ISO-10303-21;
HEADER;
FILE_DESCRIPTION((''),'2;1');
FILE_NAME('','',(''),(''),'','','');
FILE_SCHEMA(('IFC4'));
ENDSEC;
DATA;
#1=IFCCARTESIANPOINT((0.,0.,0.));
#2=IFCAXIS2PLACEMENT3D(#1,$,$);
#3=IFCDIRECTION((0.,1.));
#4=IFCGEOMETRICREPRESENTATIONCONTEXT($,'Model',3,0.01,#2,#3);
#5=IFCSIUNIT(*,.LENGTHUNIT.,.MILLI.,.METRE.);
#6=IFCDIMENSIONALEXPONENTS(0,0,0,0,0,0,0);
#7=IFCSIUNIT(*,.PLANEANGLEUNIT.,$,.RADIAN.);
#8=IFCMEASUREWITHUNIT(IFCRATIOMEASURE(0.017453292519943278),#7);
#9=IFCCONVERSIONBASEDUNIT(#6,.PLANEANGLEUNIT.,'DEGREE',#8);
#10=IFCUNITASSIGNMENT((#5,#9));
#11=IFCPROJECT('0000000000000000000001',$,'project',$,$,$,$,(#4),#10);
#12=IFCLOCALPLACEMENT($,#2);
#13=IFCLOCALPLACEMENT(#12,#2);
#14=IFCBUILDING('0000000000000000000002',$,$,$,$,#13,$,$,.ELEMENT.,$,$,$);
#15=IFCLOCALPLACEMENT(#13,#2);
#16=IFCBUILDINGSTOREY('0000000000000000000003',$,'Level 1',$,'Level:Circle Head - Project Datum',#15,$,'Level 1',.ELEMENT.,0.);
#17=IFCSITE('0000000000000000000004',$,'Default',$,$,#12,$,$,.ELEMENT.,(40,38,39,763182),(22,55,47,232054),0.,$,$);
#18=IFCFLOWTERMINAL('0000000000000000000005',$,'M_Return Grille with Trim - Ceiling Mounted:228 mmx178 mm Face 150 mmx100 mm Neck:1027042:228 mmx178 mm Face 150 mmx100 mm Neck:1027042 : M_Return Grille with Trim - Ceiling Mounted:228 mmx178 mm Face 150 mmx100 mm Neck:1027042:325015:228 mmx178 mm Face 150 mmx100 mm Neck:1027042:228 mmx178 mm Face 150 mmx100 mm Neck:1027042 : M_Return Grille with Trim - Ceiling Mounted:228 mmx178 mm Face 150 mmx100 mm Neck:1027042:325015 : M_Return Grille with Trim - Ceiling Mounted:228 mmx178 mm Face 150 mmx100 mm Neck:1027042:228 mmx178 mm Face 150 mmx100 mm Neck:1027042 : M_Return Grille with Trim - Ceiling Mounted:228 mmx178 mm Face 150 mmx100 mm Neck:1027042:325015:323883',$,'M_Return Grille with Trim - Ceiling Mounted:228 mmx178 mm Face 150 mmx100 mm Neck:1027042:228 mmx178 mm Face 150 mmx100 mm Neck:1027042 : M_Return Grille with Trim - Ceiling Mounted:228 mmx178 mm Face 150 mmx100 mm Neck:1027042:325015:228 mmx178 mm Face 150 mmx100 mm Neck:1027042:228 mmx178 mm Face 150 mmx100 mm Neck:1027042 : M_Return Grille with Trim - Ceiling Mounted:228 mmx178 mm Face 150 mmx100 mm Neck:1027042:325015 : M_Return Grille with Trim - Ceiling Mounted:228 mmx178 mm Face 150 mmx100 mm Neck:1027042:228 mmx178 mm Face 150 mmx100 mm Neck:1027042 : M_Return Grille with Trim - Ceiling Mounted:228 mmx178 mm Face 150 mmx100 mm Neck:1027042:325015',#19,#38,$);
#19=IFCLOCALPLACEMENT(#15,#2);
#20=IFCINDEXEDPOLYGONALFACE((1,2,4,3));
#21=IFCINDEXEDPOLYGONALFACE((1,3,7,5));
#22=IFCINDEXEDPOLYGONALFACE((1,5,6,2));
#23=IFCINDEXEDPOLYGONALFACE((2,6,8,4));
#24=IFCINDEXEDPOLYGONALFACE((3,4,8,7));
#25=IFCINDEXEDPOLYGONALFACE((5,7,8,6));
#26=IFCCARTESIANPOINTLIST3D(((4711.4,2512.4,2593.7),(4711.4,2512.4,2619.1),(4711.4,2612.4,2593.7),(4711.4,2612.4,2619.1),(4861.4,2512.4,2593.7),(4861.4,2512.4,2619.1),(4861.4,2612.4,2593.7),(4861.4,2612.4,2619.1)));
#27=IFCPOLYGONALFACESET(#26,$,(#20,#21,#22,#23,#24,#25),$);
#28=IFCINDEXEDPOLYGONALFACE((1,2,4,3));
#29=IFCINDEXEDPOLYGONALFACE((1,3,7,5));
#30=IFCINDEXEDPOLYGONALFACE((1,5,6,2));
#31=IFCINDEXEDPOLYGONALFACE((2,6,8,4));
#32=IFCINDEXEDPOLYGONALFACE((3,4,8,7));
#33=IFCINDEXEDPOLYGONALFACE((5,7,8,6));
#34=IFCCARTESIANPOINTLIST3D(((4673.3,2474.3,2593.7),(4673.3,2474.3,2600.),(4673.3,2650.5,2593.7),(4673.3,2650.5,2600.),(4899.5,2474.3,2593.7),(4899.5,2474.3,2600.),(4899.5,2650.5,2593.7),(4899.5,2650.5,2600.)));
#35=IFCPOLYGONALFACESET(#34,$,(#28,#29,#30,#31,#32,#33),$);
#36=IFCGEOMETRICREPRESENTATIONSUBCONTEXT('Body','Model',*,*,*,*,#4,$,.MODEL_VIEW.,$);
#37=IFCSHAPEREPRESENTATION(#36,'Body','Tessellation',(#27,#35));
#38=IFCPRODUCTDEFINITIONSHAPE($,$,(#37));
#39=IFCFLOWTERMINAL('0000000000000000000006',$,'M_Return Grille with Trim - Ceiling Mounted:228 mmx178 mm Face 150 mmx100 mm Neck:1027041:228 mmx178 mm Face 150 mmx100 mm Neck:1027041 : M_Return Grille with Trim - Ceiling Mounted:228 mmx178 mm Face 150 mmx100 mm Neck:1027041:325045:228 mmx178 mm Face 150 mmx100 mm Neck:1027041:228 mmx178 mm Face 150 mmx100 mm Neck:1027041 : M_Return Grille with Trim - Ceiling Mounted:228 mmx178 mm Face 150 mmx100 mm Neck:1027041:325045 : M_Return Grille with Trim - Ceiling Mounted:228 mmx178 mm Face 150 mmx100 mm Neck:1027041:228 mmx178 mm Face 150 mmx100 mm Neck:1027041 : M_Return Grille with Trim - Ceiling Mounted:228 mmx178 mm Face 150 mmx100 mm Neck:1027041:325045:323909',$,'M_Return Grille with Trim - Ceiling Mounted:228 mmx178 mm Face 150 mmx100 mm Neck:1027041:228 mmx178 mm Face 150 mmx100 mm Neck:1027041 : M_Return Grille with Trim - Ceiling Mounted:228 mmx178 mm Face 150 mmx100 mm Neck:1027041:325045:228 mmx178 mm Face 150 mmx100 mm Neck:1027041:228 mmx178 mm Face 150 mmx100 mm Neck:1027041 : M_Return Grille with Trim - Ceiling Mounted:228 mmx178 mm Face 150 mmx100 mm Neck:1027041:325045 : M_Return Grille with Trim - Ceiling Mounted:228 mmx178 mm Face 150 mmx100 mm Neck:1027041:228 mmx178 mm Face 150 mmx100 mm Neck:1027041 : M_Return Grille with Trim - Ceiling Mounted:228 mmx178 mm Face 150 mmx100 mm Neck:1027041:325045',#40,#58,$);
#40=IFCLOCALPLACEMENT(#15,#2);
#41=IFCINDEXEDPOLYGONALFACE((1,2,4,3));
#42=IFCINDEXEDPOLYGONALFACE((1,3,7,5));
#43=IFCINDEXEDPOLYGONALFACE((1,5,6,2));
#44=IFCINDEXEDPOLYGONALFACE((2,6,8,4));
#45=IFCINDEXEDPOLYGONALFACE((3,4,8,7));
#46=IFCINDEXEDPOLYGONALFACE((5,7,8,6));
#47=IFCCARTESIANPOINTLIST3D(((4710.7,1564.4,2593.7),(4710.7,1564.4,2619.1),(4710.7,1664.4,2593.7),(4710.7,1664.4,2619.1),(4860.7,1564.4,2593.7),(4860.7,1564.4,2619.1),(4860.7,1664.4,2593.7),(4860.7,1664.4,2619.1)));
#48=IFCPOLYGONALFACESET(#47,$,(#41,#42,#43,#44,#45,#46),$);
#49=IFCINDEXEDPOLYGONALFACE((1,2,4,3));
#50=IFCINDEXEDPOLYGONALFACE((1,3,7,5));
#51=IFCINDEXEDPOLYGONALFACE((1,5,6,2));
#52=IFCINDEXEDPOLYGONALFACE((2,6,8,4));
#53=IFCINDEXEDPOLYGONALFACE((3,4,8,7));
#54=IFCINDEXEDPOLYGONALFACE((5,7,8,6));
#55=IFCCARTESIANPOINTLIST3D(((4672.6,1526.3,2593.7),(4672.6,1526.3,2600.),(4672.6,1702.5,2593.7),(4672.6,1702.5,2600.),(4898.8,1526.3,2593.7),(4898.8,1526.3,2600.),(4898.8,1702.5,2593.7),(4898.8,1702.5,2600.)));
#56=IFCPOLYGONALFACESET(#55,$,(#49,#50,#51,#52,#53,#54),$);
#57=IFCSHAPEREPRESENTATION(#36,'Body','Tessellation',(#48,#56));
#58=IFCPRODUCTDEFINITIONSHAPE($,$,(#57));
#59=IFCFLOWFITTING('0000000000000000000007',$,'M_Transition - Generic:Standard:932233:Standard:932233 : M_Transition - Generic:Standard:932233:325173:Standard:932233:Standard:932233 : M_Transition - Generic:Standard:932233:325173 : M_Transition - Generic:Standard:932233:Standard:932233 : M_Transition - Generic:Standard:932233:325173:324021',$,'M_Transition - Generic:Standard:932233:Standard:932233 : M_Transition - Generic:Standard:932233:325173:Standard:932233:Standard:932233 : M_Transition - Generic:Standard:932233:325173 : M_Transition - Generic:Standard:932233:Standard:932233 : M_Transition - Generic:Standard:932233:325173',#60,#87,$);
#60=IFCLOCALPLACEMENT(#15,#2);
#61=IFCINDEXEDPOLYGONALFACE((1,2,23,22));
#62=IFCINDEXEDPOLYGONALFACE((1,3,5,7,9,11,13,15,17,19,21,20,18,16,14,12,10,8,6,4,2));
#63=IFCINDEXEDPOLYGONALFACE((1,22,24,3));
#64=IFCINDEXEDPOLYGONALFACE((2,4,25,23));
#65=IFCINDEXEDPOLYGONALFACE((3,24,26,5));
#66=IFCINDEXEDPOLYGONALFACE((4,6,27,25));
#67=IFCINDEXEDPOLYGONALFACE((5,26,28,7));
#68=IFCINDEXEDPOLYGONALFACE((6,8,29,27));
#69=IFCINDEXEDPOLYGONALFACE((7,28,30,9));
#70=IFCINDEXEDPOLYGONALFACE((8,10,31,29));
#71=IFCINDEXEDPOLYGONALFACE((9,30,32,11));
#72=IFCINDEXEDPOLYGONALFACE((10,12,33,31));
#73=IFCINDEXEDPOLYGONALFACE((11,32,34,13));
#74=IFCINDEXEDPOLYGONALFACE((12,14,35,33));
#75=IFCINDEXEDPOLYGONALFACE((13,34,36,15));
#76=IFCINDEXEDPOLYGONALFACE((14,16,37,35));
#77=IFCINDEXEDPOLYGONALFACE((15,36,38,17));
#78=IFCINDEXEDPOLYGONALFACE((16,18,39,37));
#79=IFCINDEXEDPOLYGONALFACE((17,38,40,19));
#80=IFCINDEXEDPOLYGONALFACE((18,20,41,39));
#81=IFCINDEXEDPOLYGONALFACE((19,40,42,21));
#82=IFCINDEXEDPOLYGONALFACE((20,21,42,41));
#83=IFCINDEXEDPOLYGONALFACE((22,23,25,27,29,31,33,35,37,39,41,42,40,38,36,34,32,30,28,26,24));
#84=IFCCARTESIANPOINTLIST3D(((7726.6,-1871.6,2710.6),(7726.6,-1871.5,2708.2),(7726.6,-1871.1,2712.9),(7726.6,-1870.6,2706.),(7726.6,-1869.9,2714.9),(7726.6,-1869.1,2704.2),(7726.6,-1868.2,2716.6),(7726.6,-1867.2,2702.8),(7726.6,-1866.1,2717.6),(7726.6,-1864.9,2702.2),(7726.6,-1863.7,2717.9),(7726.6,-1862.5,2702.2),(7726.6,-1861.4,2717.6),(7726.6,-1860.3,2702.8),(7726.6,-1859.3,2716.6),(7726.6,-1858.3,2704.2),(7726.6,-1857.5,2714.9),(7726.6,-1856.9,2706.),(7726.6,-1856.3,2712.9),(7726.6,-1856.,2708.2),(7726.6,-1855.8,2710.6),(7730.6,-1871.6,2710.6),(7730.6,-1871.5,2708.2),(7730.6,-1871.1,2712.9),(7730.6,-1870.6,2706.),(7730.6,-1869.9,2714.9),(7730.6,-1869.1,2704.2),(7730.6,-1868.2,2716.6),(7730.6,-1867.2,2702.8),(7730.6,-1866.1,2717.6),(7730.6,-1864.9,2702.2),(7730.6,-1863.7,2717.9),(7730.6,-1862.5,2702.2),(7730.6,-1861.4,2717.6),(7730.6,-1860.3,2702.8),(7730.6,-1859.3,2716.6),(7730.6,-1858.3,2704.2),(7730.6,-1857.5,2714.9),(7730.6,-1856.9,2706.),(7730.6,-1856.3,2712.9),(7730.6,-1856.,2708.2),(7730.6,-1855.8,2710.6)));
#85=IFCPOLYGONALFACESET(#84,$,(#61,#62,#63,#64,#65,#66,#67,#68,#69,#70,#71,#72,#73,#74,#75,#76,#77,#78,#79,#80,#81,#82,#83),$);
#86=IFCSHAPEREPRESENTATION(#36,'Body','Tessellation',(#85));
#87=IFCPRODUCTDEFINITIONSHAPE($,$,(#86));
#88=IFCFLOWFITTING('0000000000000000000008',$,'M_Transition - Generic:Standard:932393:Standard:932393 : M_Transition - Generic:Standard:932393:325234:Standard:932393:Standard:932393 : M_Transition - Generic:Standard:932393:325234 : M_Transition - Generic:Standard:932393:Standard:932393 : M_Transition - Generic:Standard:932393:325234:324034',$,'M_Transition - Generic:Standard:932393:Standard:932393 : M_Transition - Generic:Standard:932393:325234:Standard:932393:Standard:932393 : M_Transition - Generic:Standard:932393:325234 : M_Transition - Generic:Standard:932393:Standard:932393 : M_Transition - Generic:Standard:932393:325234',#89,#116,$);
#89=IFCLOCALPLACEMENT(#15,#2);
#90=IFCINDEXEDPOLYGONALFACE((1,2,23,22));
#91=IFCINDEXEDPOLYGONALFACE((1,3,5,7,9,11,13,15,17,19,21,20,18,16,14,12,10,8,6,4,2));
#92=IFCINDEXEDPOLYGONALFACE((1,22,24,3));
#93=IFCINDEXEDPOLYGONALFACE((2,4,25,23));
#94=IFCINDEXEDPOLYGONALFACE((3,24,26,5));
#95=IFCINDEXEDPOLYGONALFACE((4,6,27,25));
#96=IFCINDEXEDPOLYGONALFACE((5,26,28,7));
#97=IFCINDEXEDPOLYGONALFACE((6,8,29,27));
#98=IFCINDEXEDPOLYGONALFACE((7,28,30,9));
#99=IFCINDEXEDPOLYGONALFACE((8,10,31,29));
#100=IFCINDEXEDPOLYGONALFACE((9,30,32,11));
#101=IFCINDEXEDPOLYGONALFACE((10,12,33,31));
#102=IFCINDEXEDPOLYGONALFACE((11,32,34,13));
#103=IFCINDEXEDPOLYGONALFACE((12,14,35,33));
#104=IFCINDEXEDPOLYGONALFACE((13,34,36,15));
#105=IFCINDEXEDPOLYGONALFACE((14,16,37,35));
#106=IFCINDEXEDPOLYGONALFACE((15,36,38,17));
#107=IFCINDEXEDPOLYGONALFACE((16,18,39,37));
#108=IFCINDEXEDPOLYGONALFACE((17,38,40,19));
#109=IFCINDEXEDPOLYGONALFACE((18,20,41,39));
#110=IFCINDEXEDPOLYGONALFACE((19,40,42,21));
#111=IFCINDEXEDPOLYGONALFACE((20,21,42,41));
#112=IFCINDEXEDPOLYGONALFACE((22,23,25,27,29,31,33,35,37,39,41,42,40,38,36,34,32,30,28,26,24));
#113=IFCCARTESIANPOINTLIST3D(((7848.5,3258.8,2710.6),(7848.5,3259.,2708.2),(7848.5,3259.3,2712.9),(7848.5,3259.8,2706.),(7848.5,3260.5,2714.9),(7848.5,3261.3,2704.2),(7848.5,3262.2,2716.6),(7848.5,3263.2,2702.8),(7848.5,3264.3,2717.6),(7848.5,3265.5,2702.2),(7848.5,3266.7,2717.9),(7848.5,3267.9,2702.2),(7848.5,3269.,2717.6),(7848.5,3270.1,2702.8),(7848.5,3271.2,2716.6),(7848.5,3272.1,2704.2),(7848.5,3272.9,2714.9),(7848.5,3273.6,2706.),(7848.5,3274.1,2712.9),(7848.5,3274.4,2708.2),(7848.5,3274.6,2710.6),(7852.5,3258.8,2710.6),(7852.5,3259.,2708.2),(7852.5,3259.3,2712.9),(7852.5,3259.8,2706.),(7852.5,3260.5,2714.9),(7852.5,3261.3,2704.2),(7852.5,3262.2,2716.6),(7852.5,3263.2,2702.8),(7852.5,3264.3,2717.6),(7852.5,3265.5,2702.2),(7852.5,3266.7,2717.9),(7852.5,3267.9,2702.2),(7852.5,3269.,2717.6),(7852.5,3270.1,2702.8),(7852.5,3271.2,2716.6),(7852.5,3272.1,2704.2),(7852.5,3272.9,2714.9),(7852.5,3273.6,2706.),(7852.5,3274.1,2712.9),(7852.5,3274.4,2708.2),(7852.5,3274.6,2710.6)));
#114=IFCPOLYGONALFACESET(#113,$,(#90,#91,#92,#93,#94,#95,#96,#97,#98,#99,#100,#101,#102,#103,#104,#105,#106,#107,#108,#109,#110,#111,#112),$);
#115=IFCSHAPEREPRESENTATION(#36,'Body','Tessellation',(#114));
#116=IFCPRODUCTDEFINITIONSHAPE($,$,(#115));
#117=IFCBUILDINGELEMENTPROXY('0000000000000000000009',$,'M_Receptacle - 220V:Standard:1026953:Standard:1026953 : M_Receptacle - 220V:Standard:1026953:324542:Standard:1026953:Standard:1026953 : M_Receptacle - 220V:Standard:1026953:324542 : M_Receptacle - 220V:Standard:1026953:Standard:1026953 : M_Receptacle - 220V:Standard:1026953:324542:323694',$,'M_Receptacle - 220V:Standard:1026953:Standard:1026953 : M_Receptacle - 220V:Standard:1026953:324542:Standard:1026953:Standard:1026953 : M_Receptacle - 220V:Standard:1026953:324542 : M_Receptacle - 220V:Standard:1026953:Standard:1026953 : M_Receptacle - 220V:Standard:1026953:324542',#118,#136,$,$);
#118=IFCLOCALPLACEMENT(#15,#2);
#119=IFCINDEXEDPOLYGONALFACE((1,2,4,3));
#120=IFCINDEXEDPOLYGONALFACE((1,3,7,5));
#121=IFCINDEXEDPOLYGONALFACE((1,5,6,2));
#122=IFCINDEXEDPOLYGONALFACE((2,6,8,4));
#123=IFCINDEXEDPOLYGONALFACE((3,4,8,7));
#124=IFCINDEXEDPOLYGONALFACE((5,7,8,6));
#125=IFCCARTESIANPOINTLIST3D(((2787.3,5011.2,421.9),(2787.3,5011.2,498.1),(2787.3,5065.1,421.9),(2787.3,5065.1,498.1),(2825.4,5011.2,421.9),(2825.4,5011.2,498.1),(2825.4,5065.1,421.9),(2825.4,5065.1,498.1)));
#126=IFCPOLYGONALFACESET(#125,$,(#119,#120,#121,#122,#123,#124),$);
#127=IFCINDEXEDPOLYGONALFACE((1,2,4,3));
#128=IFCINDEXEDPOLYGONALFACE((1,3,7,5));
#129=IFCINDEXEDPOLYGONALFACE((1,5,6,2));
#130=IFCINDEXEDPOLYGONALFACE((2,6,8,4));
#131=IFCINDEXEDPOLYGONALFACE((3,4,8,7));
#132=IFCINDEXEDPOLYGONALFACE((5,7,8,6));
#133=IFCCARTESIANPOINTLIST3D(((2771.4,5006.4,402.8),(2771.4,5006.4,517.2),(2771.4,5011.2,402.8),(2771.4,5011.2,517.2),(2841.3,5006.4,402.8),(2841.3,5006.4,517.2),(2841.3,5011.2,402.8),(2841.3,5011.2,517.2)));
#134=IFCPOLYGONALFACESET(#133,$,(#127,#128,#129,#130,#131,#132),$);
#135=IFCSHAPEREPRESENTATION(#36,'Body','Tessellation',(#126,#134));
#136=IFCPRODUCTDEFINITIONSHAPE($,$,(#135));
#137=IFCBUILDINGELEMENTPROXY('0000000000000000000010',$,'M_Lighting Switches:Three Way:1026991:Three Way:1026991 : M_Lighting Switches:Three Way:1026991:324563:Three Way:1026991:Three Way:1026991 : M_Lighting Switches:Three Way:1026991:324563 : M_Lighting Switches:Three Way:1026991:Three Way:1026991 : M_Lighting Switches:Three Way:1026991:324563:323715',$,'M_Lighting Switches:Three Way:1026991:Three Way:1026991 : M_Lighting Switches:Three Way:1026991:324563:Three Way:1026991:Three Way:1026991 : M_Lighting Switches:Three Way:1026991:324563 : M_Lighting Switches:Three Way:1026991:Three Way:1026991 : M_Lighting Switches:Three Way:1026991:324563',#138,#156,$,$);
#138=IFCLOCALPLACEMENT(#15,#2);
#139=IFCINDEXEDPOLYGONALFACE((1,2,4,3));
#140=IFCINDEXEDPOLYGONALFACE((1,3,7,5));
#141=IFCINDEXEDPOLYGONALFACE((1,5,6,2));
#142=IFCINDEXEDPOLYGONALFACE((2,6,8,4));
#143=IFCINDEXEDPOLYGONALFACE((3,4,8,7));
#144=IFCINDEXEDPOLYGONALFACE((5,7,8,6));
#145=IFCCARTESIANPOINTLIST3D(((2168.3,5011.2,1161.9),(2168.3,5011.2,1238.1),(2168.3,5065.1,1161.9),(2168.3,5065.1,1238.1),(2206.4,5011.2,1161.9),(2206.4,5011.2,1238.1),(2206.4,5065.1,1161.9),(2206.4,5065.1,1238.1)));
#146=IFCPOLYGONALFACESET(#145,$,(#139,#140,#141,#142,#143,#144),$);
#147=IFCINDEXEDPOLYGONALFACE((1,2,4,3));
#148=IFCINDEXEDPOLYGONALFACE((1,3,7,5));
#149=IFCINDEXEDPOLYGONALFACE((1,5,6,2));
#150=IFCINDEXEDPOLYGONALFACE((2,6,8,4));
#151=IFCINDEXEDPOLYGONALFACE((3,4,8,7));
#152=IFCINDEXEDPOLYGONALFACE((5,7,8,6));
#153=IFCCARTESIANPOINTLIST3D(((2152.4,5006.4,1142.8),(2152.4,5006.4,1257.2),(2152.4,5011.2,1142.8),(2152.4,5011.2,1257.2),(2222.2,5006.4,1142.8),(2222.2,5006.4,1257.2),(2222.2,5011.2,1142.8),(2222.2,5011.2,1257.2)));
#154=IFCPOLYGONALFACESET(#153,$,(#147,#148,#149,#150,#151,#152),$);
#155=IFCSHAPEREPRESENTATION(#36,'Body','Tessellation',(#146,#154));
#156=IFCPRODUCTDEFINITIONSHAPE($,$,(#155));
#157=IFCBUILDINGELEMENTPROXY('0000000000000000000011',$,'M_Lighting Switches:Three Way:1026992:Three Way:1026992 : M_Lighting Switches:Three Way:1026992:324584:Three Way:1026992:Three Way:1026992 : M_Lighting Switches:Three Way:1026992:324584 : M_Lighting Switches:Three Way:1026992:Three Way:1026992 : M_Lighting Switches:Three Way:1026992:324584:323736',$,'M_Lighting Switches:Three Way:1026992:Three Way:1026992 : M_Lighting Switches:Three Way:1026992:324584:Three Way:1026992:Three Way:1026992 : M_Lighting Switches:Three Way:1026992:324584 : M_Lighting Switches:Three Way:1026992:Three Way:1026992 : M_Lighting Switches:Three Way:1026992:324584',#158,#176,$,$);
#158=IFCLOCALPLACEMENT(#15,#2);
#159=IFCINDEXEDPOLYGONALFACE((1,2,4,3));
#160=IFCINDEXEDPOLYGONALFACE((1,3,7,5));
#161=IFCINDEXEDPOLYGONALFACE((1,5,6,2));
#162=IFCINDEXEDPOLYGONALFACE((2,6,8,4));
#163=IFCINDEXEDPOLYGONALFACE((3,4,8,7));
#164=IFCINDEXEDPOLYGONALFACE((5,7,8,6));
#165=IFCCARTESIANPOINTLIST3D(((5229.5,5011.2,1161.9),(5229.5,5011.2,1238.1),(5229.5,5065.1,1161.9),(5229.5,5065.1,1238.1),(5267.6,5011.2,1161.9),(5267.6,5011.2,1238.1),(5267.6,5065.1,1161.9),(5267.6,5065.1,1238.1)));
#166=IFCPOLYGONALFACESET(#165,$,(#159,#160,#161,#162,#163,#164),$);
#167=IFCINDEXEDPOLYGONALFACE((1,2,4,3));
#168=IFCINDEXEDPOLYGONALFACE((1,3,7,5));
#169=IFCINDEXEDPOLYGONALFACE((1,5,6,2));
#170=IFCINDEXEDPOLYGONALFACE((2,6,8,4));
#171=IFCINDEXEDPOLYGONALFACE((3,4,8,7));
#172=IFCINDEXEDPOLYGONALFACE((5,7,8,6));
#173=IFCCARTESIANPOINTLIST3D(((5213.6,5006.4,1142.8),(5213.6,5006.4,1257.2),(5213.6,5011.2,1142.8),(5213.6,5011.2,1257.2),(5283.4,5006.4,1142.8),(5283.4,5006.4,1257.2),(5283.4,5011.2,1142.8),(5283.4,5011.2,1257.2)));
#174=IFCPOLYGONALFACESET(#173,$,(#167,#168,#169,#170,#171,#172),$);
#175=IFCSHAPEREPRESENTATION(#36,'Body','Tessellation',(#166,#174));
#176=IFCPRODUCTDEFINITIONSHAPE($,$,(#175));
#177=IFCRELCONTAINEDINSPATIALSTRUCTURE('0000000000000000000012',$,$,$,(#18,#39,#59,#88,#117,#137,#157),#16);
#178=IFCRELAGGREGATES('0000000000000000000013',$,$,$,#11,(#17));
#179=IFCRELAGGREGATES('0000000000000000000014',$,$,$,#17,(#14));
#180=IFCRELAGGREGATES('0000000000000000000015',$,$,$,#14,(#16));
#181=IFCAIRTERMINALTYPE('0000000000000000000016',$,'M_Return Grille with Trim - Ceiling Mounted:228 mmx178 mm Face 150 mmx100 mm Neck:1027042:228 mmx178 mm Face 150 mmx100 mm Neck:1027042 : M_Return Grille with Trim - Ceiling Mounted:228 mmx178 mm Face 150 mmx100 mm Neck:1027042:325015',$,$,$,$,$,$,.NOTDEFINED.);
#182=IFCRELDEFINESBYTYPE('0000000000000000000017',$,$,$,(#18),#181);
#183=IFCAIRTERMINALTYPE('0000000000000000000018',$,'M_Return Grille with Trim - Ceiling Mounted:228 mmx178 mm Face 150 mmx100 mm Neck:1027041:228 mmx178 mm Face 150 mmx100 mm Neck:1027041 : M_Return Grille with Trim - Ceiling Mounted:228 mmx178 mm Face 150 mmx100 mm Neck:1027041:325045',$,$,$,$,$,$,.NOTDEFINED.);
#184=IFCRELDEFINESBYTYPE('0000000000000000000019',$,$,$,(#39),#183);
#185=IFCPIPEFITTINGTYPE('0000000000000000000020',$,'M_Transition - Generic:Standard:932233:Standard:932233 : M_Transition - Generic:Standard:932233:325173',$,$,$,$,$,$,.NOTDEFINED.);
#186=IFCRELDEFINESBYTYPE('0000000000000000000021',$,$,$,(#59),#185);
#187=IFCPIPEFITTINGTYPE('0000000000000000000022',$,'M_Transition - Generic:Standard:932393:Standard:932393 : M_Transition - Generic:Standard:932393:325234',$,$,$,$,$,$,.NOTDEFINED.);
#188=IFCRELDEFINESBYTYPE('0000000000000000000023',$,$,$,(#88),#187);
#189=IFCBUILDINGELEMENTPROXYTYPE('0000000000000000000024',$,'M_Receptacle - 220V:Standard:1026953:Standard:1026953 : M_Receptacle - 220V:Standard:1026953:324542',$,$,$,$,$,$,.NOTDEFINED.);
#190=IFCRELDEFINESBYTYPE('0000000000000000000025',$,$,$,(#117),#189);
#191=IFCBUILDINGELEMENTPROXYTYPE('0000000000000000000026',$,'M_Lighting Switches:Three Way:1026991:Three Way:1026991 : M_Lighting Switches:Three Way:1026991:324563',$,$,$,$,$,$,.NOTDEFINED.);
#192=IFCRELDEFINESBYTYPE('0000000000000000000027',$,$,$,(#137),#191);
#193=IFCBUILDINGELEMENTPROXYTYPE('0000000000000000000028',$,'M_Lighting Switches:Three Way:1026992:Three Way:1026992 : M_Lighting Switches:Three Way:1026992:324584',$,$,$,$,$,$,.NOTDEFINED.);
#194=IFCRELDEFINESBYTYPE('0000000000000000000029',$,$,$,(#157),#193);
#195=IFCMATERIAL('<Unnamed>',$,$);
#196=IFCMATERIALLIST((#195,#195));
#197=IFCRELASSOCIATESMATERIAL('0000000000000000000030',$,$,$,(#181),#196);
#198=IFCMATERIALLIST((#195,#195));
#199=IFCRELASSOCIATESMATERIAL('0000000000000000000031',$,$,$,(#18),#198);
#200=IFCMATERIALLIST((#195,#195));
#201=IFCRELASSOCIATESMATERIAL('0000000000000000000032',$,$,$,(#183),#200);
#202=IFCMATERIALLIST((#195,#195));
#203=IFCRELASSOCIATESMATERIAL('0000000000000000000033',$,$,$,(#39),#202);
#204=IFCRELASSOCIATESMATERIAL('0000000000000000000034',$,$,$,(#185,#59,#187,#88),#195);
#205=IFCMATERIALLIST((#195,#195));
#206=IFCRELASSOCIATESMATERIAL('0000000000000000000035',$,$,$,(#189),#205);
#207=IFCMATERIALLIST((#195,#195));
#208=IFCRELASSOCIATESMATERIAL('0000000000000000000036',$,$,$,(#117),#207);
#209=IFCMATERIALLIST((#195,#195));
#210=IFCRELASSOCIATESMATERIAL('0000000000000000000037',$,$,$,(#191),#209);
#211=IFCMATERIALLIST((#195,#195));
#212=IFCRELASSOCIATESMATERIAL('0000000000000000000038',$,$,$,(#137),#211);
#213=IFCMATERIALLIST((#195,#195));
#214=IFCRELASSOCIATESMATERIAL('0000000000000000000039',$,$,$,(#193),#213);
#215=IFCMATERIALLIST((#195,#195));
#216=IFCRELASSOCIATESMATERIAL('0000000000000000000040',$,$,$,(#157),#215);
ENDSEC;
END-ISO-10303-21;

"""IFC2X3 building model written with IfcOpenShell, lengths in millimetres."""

from ifc_helpers import new_model, entity, si_unit, converted_unit, direction, frame, frame_2d, origin, origin_2d_with_axis, place, context, subcontext, project, spatial, rectangle, circle, extrude, source, transform, mapped, material, material_list, type_object, type_shapes, element, save


model = new_model("IFC2X3")

# Units and contexts
model_context = context("Model", 3, precision=0.01, world=origin(), true_north=direction((0.0, 1.0)))
body_context = subcontext(model_context, "Body", "Model", "MODEL_VIEW")
ifc_project = project(units=[si_unit("LENGTHUNIT", "METRE", prefix="MILLI"), converted_unit("PLANEANGLEUNIT", "DEGREE", entity("IfcRatioMeasure", 0.017453292519943278), si_unit("PLANEANGLEUNIT", "RADIAN"), dimensions=[0, 0, 0, 0, 0, 0, 0])], contexts=[model_context])

# Site, building, storey
site_placement = place(None, origin())
site = spatial("IfcSite", under=ifc_project, at=site_placement, Name="Default", CompositionType="ELEMENT", RefLatitude=(40, 38, 39, 763182), RefLongitude=(22, 55, 47, 232054), RefElevation=0.0)
building_placement = place(site_placement, origin())
building = spatial("IfcBuilding", under=site, at=building_placement, CompositionType="ELEMENT")
storey_placement = place(building_placement, origin())
storey = spatial("IfcBuildingStorey", under=building, at=storey_placement, Name="Level 1", ObjectType="Level:Circle Head - Project Datum", LongName="Level 1", CompositionType="ELEMENT", Elevation=0.0)

# Flow terminals
ifc_material = material(Name="<Unnamed>")
ifc_material_list_1 = material_list([ifc_material, ifc_material])
ifc_material_list_2 = material_list([ifc_material, ifc_material])
air_terminal_type_1 = type_object("IfcAirTerminalType", Name="M_Return Grille with Trim - Ceiling Mounted:228 mmx178 mm Face 150 mmx100 mm Neck:1027042:228 mmx178 mm Face 150 mmx100 mm Neck:1027042 : M_Return Grille with Trim - Ceiling Mounted:228 mmx178 mm Face 150 mmx100 mm Neck:1027042:325015", PredefinedType="NOTDEFINED", material=ifc_material_list_2)
shared_shape_1 = source(origin(), body_context, "Body", "SweptSolid", [
    extrude(rectangle(XDim=100.0, YDim=150.0, at=frame_2d((0.0, 0.0), x_axis=(1.0, 0.0))), frame((4786.4, 2562.4, 2593.7), z_axis=(0.0, 0.0, 1.0), x_axis=(0.0, 1.0, 0.0)), (0.0, 0.0, 1.0), 25.4),
    extrude(rectangle(XDim=176.2, YDim=226.2, at=origin_2d_with_axis()), frame((4786.4, 2562.4, 2593.7), z_axis=(0.0, 0.0, 1.0), x_axis=(0.0, 1.0, 0.0)), (0.0, 0.0, 1.0), 6.3),
])
type_shapes(air_terminal_type_1, [shared_shape_1])
flow_terminal_1_placement = place(storey_placement, origin())
element("IfcFlowTerminal", 1, at=flow_terminal_1_placement, inside=storey, type_object=air_terminal_type_1, material=ifc_material_list_1, Name="M_Return Grille with Trim - Ceiling Mounted:228 mmx178 mm Face 150 mmx100 mm Neck:1027042:228 mmx178 mm Face 150 mmx100 mm Neck:1027042 : M_Return Grille with Trim - Ceiling Mounted:228 mmx178 mm Face 150 mmx100 mm Neck:1027042:325015:228 mmx178 mm Face 150 mmx100 mm Neck:1027042:228 mmx178 mm Face 150 mmx100 mm Neck:1027042 : M_Return Grille with Trim - Ceiling Mounted:228 mmx178 mm Face 150 mmx100 mm Neck:1027042:325015 : M_Return Grille with Trim - Ceiling Mounted:228 mmx178 mm Face 150 mmx100 mm Neck:1027042:228 mmx178 mm Face 150 mmx100 mm Neck:1027042 : M_Return Grille with Trim - Ceiling Mounted:228 mmx178 mm Face 150 mmx100 mm Neck:1027042:325015:323883", ObjectType="M_Return Grille with Trim - Ceiling Mounted:228 mmx178 mm Face 150 mmx100 mm Neck:1027042:228 mmx178 mm Face 150 mmx100 mm Neck:1027042 : M_Return Grille with Trim - Ceiling Mounted:228 mmx178 mm Face 150 mmx100 mm Neck:1027042:325015:228 mmx178 mm Face 150 mmx100 mm Neck:1027042:228 mmx178 mm Face 150 mmx100 mm Neck:1027042 : M_Return Grille with Trim - Ceiling Mounted:228 mmx178 mm Face 150 mmx100 mm Neck:1027042:325015 : M_Return Grille with Trim - Ceiling Mounted:228 mmx178 mm Face 150 mmx100 mm Neck:1027042:228 mmx178 mm Face 150 mmx100 mm Neck:1027042 : M_Return Grille with Trim - Ceiling Mounted:228 mmx178 mm Face 150 mmx100 mm Neck:1027042:325015", context=body_context, shape_type="MappedRepresentation", body=[
    mapped(shared_shape_1, transform((0.0, 0.0, 0.0), scale=1.0)),
])
ifc_material_list_3 = material_list([ifc_material, ifc_material])
ifc_material_list_4 = material_list([ifc_material, ifc_material])
air_terminal_type_2 = type_object("IfcAirTerminalType", Name="M_Return Grille with Trim - Ceiling Mounted:228 mmx178 mm Face 150 mmx100 mm Neck:1027041:228 mmx178 mm Face 150 mmx100 mm Neck:1027041 : M_Return Grille with Trim - Ceiling Mounted:228 mmx178 mm Face 150 mmx100 mm Neck:1027041:325045", PredefinedType="NOTDEFINED", material=ifc_material_list_4)
shared_shape_2 = source(origin(), body_context, "Body", "SweptSolid", [
    extrude(rectangle(XDim=100.0, YDim=150.0, at=frame_2d((0.0, 0.0), x_axis=(1.0, 0.0))), frame((4785.7, 1614.4, 2593.7), z_axis=(0.0, 0.0, 1.0), x_axis=(0.0, 1.0, 0.0)), (0.0, 0.0, 1.0), 25.4),
    extrude(rectangle(XDim=176.2, YDim=226.2, at=frame_2d((0.0, 0.0), x_axis=(1.0, 0.0))), frame((4785.7, 1614.4, 2593.7), z_axis=(0.0, 0.0, 1.0), x_axis=(0.0, 1.0, 0.0)), (0.0, 0.0, 1.0), 6.3),
])
type_shapes(air_terminal_type_2, [shared_shape_2])
flow_terminal_2_placement = place(storey_placement, origin())
element("IfcFlowTerminal", 2, at=flow_terminal_2_placement, inside=storey, type_object=air_terminal_type_2, material=ifc_material_list_3, Name="M_Return Grille with Trim - Ceiling Mounted:228 mmx178 mm Face 150 mmx100 mm Neck:1027041:228 mmx178 mm Face 150 mmx100 mm Neck:1027041 : M_Return Grille with Trim - Ceiling Mounted:228 mmx178 mm Face 150 mmx100 mm Neck:1027041:325045:228 mmx178 mm Face 150 mmx100 mm Neck:1027041:228 mmx178 mm Face 150 mmx100 mm Neck:1027041 : M_Return Grille with Trim - Ceiling Mounted:228 mmx178 mm Face 150 mmx100 mm Neck:1027041:325045 : M_Return Grille with Trim - Ceiling Mounted:228 mmx178 mm Face 150 mmx100 mm Neck:1027041:228 mmx178 mm Face 150 mmx100 mm Neck:1027041 : M_Return Grille with Trim - Ceiling Mounted:228 mmx178 mm Face 150 mmx100 mm Neck:1027041:325045:323909", ObjectType="M_Return Grille with Trim - Ceiling Mounted:228 mmx178 mm Face 150 mmx100 mm Neck:1027041:228 mmx178 mm Face 150 mmx100 mm Neck:1027041 : M_Return Grille with Trim - Ceiling Mounted:228 mmx178 mm Face 150 mmx100 mm Neck:1027041:325045:228 mmx178 mm Face 150 mmx100 mm Neck:1027041:228 mmx178 mm Face 150 mmx100 mm Neck:1027041 : M_Return Grille with Trim - Ceiling Mounted:228 mmx178 mm Face 150 mmx100 mm Neck:1027041:325045 : M_Return Grille with Trim - Ceiling Mounted:228 mmx178 mm Face 150 mmx100 mm Neck:1027041:228 mmx178 mm Face 150 mmx100 mm Neck:1027041 : M_Return Grille with Trim - Ceiling Mounted:228 mmx178 mm Face 150 mmx100 mm Neck:1027041:325045", context=body_context, shape_type="MappedRepresentation", body=[
    mapped(shared_shape_2, transform((0.0, 0.0, 0.0), scale=1.0)),
])

# Flow fittings
pipe_fitting_type_1 = type_object("IfcPipeFittingType", Name="M_Transition - Generic:Standard:932233:Standard:932233 : M_Transition - Generic:Standard:932233:325173", PredefinedType="NOTDEFINED", material=ifc_material)
shared_shape_3 = source(origin(), body_context, "Body", "SweptSolid", [
    extrude(circle(Radius=7.9, at=origin_2d_with_axis()), frame((7726.6, -1863.7, 2710.0), z_axis=(1.0, 0.0, 0.0), x_axis=(0.0, 0.0, 1.0)), (0.0, 0.0, 1.0), 4.0),
])
type_shapes(pipe_fitting_type_1, [shared_shape_3])
flow_fitting_1_placement = place(storey_placement, origin())
element("IfcFlowFitting", 3, at=flow_fitting_1_placement, inside=storey, type_object=pipe_fitting_type_1, material=ifc_material, Name="M_Transition - Generic:Standard:932233:Standard:932233 : M_Transition - Generic:Standard:932233:325173:Standard:932233:Standard:932233 : M_Transition - Generic:Standard:932233:325173 : M_Transition - Generic:Standard:932233:Standard:932233 : M_Transition - Generic:Standard:932233:325173:324021", ObjectType="M_Transition - Generic:Standard:932233:Standard:932233 : M_Transition - Generic:Standard:932233:325173:Standard:932233:Standard:932233 : M_Transition - Generic:Standard:932233:325173 : M_Transition - Generic:Standard:932233:Standard:932233 : M_Transition - Generic:Standard:932233:325173", context=body_context, shape_type="MappedRepresentation", body=[
    mapped(shared_shape_3, transform((0.0, 0.0, 0.0), scale=1.0)),
])
pipe_fitting_type_2 = type_object("IfcPipeFittingType", Name="M_Transition - Generic:Standard:932393:Standard:932393 : M_Transition - Generic:Standard:932393:325234", PredefinedType="NOTDEFINED", material=ifc_material)
shared_shape_4 = source(origin(), body_context, "Body", "SweptSolid", [
    extrude(circle(Radius=7.9, at=origin_2d_with_axis()), frame((7848.5, 3266.7, 2710.0), z_axis=(1.0, 0.0, 0.0), x_axis=(0.0, 0.0, 1.0)), (0.0, 0.0, 1.0), 4.0),
])
type_shapes(pipe_fitting_type_2, [shared_shape_4])
flow_fitting_2_placement = place(storey_placement, origin())
element("IfcFlowFitting", 4, at=flow_fitting_2_placement, inside=storey, type_object=pipe_fitting_type_2, material=ifc_material, Name="M_Transition - Generic:Standard:932393:Standard:932393 : M_Transition - Generic:Standard:932393:325234:Standard:932393:Standard:932393 : M_Transition - Generic:Standard:932393:325234 : M_Transition - Generic:Standard:932393:Standard:932393 : M_Transition - Generic:Standard:932393:325234:324034", ObjectType="M_Transition - Generic:Standard:932393:Standard:932393 : M_Transition - Generic:Standard:932393:325234:Standard:932393:Standard:932393 : M_Transition - Generic:Standard:932393:325234 : M_Transition - Generic:Standard:932393:Standard:932393 : M_Transition - Generic:Standard:932393:325234", context=body_context, shape_type="MappedRepresentation", body=[
    mapped(shared_shape_4, transform((0.0, 0.0, 0.0), scale=1.0)),
])

# Building element proxies
ifc_material_list_5 = material_list([ifc_material, ifc_material])
ifc_material_list_6 = material_list([ifc_material, ifc_material])
building_element_proxy_type_1 = type_object("IfcBuildingElementProxyType", Name="M_Receptacle - 220V:Standard:1026953:Standard:1026953 : M_Receptacle - 220V:Standard:1026953:324542", PredefinedType="NOTDEFINED", material=ifc_material_list_6)
shared_shape_5 = source(origin(), body_context, "Body", "SweptSolid", [
    extrude(rectangle(XDim=38.1, YDim=54.0, at=frame_2d((0.0, 0.0), x_axis=(1.0, 0.0))), frame((2806.3, 5038.1, 421.9), z_axis=(0.0, 0.0, 1.0), x_axis=(-1.0, 0.0, 0.0)), (0.0, 0.0, 1.0), 76.2),
    extrude(rectangle(XDim=69.8, YDim=4.8, at=frame_2d((0.0, 0.0), x_axis=(1.0, 0.0))), frame((2806.3, 5008.8, 402.8), z_axis=(0.0, 0.0, 1.0), x_axis=(-1.0, 0.0, 0.0)), (0.0, 0.0, 1.0), 114.3),
])
type_shapes(building_element_proxy_type_1, [shared_shape_5])
proxy_1_placement = place(storey_placement, origin())
element("IfcBuildingElementProxy", 5, at=proxy_1_placement, inside=storey, type_object=building_element_proxy_type_1, material=ifc_material_list_5, Name="M_Receptacle - 220V:Standard:1026953:Standard:1026953 : M_Receptacle - 220V:Standard:1026953:324542:Standard:1026953:Standard:1026953 : M_Receptacle - 220V:Standard:1026953:324542 : M_Receptacle - 220V:Standard:1026953:Standard:1026953 : M_Receptacle - 220V:Standard:1026953:324542:323694", ObjectType="M_Receptacle - 220V:Standard:1026953:Standard:1026953 : M_Receptacle - 220V:Standard:1026953:324542:Standard:1026953:Standard:1026953 : M_Receptacle - 220V:Standard:1026953:324542 : M_Receptacle - 220V:Standard:1026953:Standard:1026953 : M_Receptacle - 220V:Standard:1026953:324542", context=body_context, shape_type="MappedRepresentation", body=[
    mapped(shared_shape_5, transform((0.0, 0.0, 0.0), scale=1.0)),
])
ifc_material_list_7 = material_list([ifc_material, ifc_material])
ifc_material_list_8 = material_list([ifc_material, ifc_material])
building_element_proxy_type_2 = type_object("IfcBuildingElementProxyType", Name="M_Lighting Switches:Three Way:1026991:Three Way:1026991 : M_Lighting Switches:Three Way:1026991:324563", PredefinedType="NOTDEFINED", material=ifc_material_list_8)
shared_shape_6 = source(origin(), body_context, "Body", "SweptSolid", [
    extrude(rectangle(XDim=38.1, YDim=54.0, at=frame_2d((0.0, 0.0), x_axis=(1.0, 0.0))), frame((2187.3, 5038.1, 1161.9), z_axis=(0.0, 0.0, 1.0), x_axis=(-1.0, 0.0, 0.0)), (0.0, 0.0, 1.0), 76.2),
    extrude(rectangle(XDim=69.8, YDim=4.8, at=frame_2d((0.0, 0.0), x_axis=(1.0, 0.0))), frame((2187.3, 5008.8, 1142.8), z_axis=(0.0, 0.0, 1.0), x_axis=(-1.0, 0.0, 0.0)), (0.0, 0.0, 1.0), 114.3),
])
type_shapes(building_element_proxy_type_2, [shared_shape_6])
proxy_2_placement = place(storey_placement, origin())
element("IfcBuildingElementProxy", 6, at=proxy_2_placement, inside=storey, type_object=building_element_proxy_type_2, material=ifc_material_list_7, Name="M_Lighting Switches:Three Way:1026991:Three Way:1026991 : M_Lighting Switches:Three Way:1026991:324563:Three Way:1026991:Three Way:1026991 : M_Lighting Switches:Three Way:1026991:324563 : M_Lighting Switches:Three Way:1026991:Three Way:1026991 : M_Lighting Switches:Three Way:1026991:324563:323715", ObjectType="M_Lighting Switches:Three Way:1026991:Three Way:1026991 : M_Lighting Switches:Three Way:1026991:324563:Three Way:1026991:Three Way:1026991 : M_Lighting Switches:Three Way:1026991:324563 : M_Lighting Switches:Three Way:1026991:Three Way:1026991 : M_Lighting Switches:Three Way:1026991:324563", context=body_context, shape_type="MappedRepresentation", body=[
    mapped(shared_shape_6, transform((0.0, 0.0, 0.0), scale=1.0)),
])
ifc_material_list_9 = material_list([ifc_material, ifc_material])
ifc_material_list_10 = material_list([ifc_material, ifc_material])
building_element_proxy_type_3 = type_object("IfcBuildingElementProxyType", Name="M_Lighting Switches:Three Way:1026992:Three Way:1026992 : M_Lighting Switches:Three Way:1026992:324584", PredefinedType="NOTDEFINED", material=ifc_material_list_10)
shared_shape_7 = source(origin(), body_context, "Body", "SweptSolid", [
    extrude(rectangle(XDim=38.1, YDim=54.0, at=origin_2d_with_axis()), frame((5248.5, 5038.1, 1161.9), z_axis=(0.0, 0.0, 1.0), x_axis=(-1.0, 0.0, 0.0)), (0.0, 0.0, 1.0), 76.2),
    extrude(rectangle(XDim=69.8, YDim=4.8, at=frame_2d((0.0, 0.0), x_axis=(1.0, 0.0))), frame((5248.5, 5008.8, 1142.8), z_axis=(0.0, 0.0, 1.0), x_axis=(-1.0, 0.0, 0.0)), (0.0, 0.0, 1.0), 114.3),
])
type_shapes(building_element_proxy_type_3, [shared_shape_7])
proxy_3_placement = place(storey_placement, origin())
element("IfcBuildingElementProxy", 7, at=proxy_3_placement, inside=storey, type_object=building_element_proxy_type_3, material=ifc_material_list_9, Name="M_Lighting Switches:Three Way:1026992:Three Way:1026992 : M_Lighting Switches:Three Way:1026992:324584:Three Way:1026992:Three Way:1026992 : M_Lighting Switches:Three Way:1026992:324584 : M_Lighting Switches:Three Way:1026992:Three Way:1026992 : M_Lighting Switches:Three Way:1026992:324584:323736", ObjectType="M_Lighting Switches:Three Way:1026992:Three Way:1026992 : M_Lighting Switches:Three Way:1026992:324584:Three Way:1026992:Three Way:1026992 : M_Lighting Switches:Three Way:1026992:324584 : M_Lighting Switches:Three Way:1026992:Three Way:1026992 : M_Lighting Switches:Three Way:1026992:324584", context=body_context, shape_type="MappedRepresentation", body=[
    mapped(shared_shape_7, transform((0.0, 0.0, 0.0), scale=1.0)),
])

save(model, "model.ifc")
